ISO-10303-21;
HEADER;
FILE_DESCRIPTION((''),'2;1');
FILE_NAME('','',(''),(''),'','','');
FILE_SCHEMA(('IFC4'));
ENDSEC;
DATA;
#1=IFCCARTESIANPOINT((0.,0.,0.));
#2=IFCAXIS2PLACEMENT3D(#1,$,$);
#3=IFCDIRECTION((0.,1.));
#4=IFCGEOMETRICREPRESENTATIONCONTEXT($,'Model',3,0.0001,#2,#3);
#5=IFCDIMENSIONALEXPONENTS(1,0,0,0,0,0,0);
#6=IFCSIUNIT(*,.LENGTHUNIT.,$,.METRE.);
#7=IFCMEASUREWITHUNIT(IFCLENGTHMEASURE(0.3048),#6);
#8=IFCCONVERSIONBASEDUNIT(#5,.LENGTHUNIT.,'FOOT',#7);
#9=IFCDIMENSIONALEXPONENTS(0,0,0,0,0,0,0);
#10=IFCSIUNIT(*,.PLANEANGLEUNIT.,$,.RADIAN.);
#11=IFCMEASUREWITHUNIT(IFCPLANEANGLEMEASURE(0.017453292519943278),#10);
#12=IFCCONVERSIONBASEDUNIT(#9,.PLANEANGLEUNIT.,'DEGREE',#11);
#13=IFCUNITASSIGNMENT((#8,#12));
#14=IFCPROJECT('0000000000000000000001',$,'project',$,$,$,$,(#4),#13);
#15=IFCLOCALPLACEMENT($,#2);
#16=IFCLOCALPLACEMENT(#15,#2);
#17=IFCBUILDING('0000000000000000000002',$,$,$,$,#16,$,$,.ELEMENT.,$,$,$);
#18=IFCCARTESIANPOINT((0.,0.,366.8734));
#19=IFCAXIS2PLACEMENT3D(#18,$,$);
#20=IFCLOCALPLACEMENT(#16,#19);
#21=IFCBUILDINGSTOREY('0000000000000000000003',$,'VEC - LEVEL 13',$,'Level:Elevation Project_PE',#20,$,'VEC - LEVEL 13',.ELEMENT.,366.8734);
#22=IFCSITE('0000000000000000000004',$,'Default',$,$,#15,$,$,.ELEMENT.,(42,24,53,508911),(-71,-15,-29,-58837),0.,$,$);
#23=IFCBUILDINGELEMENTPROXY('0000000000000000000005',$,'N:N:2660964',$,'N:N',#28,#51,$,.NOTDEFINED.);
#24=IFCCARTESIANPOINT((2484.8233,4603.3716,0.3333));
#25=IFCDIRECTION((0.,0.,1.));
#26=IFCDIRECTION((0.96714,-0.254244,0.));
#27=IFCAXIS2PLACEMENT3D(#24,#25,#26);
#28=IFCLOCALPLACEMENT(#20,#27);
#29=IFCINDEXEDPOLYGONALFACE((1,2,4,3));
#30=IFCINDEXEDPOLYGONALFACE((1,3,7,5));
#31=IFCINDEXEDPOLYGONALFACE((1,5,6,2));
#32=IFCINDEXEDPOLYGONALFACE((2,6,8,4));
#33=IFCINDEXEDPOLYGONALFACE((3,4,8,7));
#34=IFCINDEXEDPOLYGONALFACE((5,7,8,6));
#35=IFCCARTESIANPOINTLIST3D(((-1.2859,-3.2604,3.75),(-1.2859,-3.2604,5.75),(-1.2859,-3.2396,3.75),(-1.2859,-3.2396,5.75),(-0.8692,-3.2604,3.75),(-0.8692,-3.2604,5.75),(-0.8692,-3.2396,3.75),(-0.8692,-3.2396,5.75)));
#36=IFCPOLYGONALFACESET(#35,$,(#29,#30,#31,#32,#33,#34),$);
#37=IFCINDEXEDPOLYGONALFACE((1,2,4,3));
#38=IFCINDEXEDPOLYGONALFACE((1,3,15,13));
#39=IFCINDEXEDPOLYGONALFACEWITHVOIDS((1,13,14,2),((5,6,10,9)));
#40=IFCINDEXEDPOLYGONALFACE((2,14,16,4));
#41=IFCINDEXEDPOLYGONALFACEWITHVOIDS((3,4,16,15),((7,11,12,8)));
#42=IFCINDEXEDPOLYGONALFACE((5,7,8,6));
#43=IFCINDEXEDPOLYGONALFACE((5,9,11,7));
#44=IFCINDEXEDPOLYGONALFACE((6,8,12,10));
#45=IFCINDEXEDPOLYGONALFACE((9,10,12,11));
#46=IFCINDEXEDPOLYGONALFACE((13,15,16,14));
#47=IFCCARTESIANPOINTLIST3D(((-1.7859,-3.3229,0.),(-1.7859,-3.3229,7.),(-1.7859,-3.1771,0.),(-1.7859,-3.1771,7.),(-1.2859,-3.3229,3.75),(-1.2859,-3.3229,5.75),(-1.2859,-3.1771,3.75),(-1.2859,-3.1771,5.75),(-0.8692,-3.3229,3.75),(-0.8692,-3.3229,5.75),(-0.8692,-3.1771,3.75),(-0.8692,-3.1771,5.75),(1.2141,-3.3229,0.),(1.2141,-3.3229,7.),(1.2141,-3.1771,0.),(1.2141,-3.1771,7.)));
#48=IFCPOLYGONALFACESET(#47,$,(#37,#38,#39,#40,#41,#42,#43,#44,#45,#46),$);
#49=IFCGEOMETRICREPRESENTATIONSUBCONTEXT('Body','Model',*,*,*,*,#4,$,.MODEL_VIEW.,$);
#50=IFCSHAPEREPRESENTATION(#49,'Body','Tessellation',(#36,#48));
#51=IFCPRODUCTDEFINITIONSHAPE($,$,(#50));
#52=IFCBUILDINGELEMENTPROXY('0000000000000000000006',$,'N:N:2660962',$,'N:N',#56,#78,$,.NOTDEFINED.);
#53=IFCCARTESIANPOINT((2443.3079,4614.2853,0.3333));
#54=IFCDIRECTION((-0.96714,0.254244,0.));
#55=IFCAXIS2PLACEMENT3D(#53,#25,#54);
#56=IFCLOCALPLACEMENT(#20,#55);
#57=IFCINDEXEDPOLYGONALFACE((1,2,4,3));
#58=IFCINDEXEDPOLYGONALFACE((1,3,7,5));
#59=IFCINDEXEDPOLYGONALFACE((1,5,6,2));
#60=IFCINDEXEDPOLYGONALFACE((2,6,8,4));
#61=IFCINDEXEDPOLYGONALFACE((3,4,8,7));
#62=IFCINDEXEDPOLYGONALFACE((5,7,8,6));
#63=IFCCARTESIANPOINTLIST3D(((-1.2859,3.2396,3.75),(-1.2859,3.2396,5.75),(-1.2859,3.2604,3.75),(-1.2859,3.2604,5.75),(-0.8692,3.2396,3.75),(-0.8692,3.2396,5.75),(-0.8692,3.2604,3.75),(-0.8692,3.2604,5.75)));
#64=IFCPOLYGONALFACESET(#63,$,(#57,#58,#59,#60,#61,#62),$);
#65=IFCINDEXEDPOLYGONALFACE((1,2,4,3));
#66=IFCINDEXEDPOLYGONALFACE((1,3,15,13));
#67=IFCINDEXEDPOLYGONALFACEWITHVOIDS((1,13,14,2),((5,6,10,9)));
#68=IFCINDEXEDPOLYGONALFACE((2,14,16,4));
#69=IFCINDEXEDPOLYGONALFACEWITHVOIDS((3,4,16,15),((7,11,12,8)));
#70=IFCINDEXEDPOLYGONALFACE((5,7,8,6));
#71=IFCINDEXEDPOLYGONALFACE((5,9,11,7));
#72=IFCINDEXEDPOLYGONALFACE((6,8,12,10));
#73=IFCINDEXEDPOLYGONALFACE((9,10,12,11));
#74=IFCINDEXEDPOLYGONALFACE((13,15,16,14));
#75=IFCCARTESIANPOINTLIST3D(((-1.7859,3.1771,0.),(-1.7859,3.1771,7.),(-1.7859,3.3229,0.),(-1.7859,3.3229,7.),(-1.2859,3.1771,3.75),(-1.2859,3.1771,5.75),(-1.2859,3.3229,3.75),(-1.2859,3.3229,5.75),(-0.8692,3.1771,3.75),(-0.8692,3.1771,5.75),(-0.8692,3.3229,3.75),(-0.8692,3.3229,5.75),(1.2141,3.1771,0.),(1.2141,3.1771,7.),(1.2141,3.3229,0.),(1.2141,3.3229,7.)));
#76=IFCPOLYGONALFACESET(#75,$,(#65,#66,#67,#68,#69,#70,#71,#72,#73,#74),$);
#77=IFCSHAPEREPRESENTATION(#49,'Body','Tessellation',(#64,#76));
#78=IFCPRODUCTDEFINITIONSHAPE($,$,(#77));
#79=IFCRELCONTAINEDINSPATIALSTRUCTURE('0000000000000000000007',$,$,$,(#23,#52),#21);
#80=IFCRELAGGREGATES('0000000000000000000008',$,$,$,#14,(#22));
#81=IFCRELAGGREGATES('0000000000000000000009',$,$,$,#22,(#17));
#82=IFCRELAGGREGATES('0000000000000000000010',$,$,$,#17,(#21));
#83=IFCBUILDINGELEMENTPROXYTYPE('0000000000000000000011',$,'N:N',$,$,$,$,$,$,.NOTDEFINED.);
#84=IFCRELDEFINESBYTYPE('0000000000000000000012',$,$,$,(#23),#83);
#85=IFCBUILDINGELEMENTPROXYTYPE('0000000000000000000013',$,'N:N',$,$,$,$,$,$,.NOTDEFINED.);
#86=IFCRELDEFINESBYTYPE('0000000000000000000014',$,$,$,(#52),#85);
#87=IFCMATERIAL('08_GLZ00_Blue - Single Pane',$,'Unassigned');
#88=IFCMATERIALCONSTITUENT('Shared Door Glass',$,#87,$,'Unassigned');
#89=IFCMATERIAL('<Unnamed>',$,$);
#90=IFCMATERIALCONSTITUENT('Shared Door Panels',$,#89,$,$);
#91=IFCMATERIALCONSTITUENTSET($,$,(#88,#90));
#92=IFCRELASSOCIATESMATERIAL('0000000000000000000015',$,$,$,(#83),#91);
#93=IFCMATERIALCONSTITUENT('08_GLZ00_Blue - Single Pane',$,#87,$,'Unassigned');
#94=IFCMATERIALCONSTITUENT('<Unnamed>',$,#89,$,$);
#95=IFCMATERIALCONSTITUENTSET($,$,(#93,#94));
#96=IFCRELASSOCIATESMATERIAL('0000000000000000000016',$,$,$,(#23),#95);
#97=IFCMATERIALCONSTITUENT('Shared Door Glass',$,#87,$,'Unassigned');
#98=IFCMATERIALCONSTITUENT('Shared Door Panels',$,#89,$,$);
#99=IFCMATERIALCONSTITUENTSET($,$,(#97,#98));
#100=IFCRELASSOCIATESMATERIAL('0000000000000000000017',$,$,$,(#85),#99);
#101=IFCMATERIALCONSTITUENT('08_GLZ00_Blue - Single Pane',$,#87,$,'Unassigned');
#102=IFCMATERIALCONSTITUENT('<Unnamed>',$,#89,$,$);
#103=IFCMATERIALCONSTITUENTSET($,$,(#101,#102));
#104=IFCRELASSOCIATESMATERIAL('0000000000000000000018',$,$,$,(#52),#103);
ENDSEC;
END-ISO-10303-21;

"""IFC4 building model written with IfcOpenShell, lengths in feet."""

from ifc_helpers import new_model, entity, si_unit, converted_unit, direction, frame, origin, place, context, subcontext, project, spatial, indexed_curve, outline, extrude, source, transform, mapped, material, constituent, constituent_set, type_object, type_shapes, element, save


model = new_model("IFC4")

# Units and contexts
model_context = context("Model", 3, precision=0.0001, world=origin(), true_north=direction((0.0, 1.0)))
body_context = subcontext(model_context, "Body", "Model", "MODEL_VIEW")
ifc_project = project(units=[converted_unit("LENGTHUNIT", "FOOT", entity("IfcLengthMeasure", 0.3048), si_unit("LENGTHUNIT", "METRE"), dimensions=[1, 0, 0, 0, 0, 0, 0]), converted_unit("PLANEANGLEUNIT", "DEGREE", entity("IfcPlaneAngleMeasure", 0.017453292519943278), si_unit("PLANEANGLEUNIT", "RADIAN"), dimensions=[0, 0, 0, 0, 0, 0, 0])], contexts=[model_context])

# Site, building, storey
site_placement = place(None, origin())
site = spatial("IfcSite", under=ifc_project, at=site_placement, Name="Default", CompositionType="ELEMENT", RefLatitude=(42, 24, 53, 508911), RefLongitude=(-71, -15, -29, -58837), RefElevation=0.0)
building_placement = place(site_placement, origin())
building = spatial("IfcBuilding", under=site, at=building_placement, CompositionType="ELEMENT")
storey_placement = place(building_placement, frame((0.0, 0.0, 366.8734)))
storey = spatial("IfcBuildingStorey", under=building, at=storey_placement, Name="VEC - LEVEL 13", ObjectType="Level:Elevation Project_PE", LongName="VEC - LEVEL 13", CompositionType="ELEMENT", Elevation=366.8734)

# Shared definitions
ifc_material_1 = material(Name="<Unnamed>")

# Building element proxies
ifc_material_2 = material(Name="08_GLZ00_Blue - Single Pane", Category="Unassigned")
ifc_constituent_1 = constituent(ifc_material_2, Name="08_GLZ00_Blue - Single Pane", Category="Unassigned")
ifc_constituent_2 = constituent(ifc_material_1, Name="<Unnamed>")
ifc_constituent_set_1 = constituent_set(constituents=[ifc_constituent_1, ifc_constituent_2])
ifc_constituent_3 = constituent(ifc_material_2, Name="Shared Door Glass", Category="Unassigned")
ifc_constituent_4 = constituent(ifc_material_1, Name="Shared Door Panels")
ifc_constituent_set_2 = constituent_set(constituents=[ifc_constituent_3, ifc_constituent_4])
building_element_proxy_type_1 = type_object("IfcBuildingElementProxyType", Name="N:N", PredefinedType="NOTDEFINED", material=ifc_constituent_set_2)
shared_shape_1 = source(origin(), body_context, "Body", "SweptSolid", [
    extrude(outline(indexed_curve([(-0.2083, -0.0104), (0.2083, -0.0104), (0.2083, 0.0104), (-0.2083, 0.0104), (-0.2083, -0.0104)], self_intersect=False)), frame((-1.0775, -3.25, 3.75), z_axis=(0.0, 0.0, 1.0), x_axis=(-1.0, 0.0, 0.0)), (0.0, 0.0, 1.0), 2.0),
    extrude(outline(indexed_curve([(-3.5, -1.5), (3.5, -1.5), (3.5, 1.5), (-3.5, 1.5), (-3.5, -1.5)], self_intersect=False), holes=[indexed_curve([(-2.25, 0.5833), (-2.25, 1.0), (-0.25, 1.0), (-0.25, 0.5833), (-2.25, 0.5833)], self_intersect=False)]), frame((-0.2859, -3.3229, 3.5), z_axis=(0.0, 1.0, 0.0), x_axis=(0.0, 0.0, -1.0)), (0.0, 0.0, 1.0), 0.1458),
])
type_shapes(building_element_proxy_type_1, [shared_shape_1])
proxy_1_placement = place(storey_placement, frame((2484.8233, 4603.3716, 0.3333), z_axis=(0.0, 0.0, 1.0), x_axis=(0.96714, -0.254244, 0.0)))
element("IfcBuildingElementProxy", 1, at=proxy_1_placement, inside=storey, type_object=building_element_proxy_type_1, material=ifc_constituent_set_1, Name="N:N:2660964", ObjectType="N:N", PredefinedType="NOTDEFINED", context=body_context, shape_type="MappedRepresentation", body=[
    mapped(shared_shape_1, transform((0.0, 0.0, 0.0), scale=1.0)),
])
ifc_constituent_5 = constituent(ifc_material_2, Name="08_GLZ00_Blue - Single Pane", Category="Unassigned")
ifc_constituent_6 = constituent(ifc_material_1, Name="<Unnamed>")
ifc_constituent_set_3 = constituent_set(constituents=[ifc_constituent_5, ifc_constituent_6])
ifc_constituent_7 = constituent(ifc_material_2, Name="Shared Door Glass", Category="Unassigned")
ifc_constituent_8 = constituent(ifc_material_1, Name="Shared Door Panels")
ifc_constituent_set_4 = constituent_set(constituents=[ifc_constituent_7, ifc_constituent_8])
building_element_proxy_type_2 = type_object("IfcBuildingElementProxyType", Name="N:N", PredefinedType="NOTDEFINED", material=ifc_constituent_set_4)
shared_shape_2 = source(origin(), body_context, "Body", "SweptSolid", [
    extrude(outline(indexed_curve([(-0.0104, -0.2083), (0.0104, -0.2083), (0.0104, 0.2083), (-0.0104, 0.2083), (-0.0104, -0.2083)], self_intersect=False)), frame((-1.0775, 3.25, 3.75), z_axis=(0.0, 0.0, 1.0), x_axis=(0.0, 1.0, 0.0)), (0.0, 0.0, 1.0), 2.0),
    extrude(outline(indexed_curve([(-3.5, -1.5), (3.5, -1.5), (3.5, 1.5), (-3.5, 1.5), (-3.5, -1.5)], self_intersect=False), holes=[indexed_curve([(-2.25, 0.5833), (-2.25, 1.0), (-0.25, 1.0), (-0.25, 0.5833), (-2.25, 0.5833)], self_intersect=False)]), frame((-0.2859, 3.1771, 3.5), z_axis=(0.0, 1.0, 0.0), x_axis=(0.0, 0.0, -1.0)), (0.0, 0.0, 1.0), 0.1458),
])
type_shapes(building_element_proxy_type_2, [shared_shape_2])
proxy_2_placement = place(storey_placement, frame((2443.3079, 4614.2853, 0.3333), z_axis=(0.0, 0.0, 1.0), x_axis=(-0.96714, 0.254244, 0.0)))
element("IfcBuildingElementProxy", 2, at=proxy_2_placement, inside=storey, type_object=building_element_proxy_type_2, material=ifc_constituent_set_3, Name="N:N:2660962", ObjectType="N:N", PredefinedType="NOTDEFINED", context=body_context, shape_type="MappedRepresentation", body=[
    mapped(shared_shape_2, transform((0.0, 0.0, 0.0), scale=1.0)),
])

save(model, "model.ifc")
